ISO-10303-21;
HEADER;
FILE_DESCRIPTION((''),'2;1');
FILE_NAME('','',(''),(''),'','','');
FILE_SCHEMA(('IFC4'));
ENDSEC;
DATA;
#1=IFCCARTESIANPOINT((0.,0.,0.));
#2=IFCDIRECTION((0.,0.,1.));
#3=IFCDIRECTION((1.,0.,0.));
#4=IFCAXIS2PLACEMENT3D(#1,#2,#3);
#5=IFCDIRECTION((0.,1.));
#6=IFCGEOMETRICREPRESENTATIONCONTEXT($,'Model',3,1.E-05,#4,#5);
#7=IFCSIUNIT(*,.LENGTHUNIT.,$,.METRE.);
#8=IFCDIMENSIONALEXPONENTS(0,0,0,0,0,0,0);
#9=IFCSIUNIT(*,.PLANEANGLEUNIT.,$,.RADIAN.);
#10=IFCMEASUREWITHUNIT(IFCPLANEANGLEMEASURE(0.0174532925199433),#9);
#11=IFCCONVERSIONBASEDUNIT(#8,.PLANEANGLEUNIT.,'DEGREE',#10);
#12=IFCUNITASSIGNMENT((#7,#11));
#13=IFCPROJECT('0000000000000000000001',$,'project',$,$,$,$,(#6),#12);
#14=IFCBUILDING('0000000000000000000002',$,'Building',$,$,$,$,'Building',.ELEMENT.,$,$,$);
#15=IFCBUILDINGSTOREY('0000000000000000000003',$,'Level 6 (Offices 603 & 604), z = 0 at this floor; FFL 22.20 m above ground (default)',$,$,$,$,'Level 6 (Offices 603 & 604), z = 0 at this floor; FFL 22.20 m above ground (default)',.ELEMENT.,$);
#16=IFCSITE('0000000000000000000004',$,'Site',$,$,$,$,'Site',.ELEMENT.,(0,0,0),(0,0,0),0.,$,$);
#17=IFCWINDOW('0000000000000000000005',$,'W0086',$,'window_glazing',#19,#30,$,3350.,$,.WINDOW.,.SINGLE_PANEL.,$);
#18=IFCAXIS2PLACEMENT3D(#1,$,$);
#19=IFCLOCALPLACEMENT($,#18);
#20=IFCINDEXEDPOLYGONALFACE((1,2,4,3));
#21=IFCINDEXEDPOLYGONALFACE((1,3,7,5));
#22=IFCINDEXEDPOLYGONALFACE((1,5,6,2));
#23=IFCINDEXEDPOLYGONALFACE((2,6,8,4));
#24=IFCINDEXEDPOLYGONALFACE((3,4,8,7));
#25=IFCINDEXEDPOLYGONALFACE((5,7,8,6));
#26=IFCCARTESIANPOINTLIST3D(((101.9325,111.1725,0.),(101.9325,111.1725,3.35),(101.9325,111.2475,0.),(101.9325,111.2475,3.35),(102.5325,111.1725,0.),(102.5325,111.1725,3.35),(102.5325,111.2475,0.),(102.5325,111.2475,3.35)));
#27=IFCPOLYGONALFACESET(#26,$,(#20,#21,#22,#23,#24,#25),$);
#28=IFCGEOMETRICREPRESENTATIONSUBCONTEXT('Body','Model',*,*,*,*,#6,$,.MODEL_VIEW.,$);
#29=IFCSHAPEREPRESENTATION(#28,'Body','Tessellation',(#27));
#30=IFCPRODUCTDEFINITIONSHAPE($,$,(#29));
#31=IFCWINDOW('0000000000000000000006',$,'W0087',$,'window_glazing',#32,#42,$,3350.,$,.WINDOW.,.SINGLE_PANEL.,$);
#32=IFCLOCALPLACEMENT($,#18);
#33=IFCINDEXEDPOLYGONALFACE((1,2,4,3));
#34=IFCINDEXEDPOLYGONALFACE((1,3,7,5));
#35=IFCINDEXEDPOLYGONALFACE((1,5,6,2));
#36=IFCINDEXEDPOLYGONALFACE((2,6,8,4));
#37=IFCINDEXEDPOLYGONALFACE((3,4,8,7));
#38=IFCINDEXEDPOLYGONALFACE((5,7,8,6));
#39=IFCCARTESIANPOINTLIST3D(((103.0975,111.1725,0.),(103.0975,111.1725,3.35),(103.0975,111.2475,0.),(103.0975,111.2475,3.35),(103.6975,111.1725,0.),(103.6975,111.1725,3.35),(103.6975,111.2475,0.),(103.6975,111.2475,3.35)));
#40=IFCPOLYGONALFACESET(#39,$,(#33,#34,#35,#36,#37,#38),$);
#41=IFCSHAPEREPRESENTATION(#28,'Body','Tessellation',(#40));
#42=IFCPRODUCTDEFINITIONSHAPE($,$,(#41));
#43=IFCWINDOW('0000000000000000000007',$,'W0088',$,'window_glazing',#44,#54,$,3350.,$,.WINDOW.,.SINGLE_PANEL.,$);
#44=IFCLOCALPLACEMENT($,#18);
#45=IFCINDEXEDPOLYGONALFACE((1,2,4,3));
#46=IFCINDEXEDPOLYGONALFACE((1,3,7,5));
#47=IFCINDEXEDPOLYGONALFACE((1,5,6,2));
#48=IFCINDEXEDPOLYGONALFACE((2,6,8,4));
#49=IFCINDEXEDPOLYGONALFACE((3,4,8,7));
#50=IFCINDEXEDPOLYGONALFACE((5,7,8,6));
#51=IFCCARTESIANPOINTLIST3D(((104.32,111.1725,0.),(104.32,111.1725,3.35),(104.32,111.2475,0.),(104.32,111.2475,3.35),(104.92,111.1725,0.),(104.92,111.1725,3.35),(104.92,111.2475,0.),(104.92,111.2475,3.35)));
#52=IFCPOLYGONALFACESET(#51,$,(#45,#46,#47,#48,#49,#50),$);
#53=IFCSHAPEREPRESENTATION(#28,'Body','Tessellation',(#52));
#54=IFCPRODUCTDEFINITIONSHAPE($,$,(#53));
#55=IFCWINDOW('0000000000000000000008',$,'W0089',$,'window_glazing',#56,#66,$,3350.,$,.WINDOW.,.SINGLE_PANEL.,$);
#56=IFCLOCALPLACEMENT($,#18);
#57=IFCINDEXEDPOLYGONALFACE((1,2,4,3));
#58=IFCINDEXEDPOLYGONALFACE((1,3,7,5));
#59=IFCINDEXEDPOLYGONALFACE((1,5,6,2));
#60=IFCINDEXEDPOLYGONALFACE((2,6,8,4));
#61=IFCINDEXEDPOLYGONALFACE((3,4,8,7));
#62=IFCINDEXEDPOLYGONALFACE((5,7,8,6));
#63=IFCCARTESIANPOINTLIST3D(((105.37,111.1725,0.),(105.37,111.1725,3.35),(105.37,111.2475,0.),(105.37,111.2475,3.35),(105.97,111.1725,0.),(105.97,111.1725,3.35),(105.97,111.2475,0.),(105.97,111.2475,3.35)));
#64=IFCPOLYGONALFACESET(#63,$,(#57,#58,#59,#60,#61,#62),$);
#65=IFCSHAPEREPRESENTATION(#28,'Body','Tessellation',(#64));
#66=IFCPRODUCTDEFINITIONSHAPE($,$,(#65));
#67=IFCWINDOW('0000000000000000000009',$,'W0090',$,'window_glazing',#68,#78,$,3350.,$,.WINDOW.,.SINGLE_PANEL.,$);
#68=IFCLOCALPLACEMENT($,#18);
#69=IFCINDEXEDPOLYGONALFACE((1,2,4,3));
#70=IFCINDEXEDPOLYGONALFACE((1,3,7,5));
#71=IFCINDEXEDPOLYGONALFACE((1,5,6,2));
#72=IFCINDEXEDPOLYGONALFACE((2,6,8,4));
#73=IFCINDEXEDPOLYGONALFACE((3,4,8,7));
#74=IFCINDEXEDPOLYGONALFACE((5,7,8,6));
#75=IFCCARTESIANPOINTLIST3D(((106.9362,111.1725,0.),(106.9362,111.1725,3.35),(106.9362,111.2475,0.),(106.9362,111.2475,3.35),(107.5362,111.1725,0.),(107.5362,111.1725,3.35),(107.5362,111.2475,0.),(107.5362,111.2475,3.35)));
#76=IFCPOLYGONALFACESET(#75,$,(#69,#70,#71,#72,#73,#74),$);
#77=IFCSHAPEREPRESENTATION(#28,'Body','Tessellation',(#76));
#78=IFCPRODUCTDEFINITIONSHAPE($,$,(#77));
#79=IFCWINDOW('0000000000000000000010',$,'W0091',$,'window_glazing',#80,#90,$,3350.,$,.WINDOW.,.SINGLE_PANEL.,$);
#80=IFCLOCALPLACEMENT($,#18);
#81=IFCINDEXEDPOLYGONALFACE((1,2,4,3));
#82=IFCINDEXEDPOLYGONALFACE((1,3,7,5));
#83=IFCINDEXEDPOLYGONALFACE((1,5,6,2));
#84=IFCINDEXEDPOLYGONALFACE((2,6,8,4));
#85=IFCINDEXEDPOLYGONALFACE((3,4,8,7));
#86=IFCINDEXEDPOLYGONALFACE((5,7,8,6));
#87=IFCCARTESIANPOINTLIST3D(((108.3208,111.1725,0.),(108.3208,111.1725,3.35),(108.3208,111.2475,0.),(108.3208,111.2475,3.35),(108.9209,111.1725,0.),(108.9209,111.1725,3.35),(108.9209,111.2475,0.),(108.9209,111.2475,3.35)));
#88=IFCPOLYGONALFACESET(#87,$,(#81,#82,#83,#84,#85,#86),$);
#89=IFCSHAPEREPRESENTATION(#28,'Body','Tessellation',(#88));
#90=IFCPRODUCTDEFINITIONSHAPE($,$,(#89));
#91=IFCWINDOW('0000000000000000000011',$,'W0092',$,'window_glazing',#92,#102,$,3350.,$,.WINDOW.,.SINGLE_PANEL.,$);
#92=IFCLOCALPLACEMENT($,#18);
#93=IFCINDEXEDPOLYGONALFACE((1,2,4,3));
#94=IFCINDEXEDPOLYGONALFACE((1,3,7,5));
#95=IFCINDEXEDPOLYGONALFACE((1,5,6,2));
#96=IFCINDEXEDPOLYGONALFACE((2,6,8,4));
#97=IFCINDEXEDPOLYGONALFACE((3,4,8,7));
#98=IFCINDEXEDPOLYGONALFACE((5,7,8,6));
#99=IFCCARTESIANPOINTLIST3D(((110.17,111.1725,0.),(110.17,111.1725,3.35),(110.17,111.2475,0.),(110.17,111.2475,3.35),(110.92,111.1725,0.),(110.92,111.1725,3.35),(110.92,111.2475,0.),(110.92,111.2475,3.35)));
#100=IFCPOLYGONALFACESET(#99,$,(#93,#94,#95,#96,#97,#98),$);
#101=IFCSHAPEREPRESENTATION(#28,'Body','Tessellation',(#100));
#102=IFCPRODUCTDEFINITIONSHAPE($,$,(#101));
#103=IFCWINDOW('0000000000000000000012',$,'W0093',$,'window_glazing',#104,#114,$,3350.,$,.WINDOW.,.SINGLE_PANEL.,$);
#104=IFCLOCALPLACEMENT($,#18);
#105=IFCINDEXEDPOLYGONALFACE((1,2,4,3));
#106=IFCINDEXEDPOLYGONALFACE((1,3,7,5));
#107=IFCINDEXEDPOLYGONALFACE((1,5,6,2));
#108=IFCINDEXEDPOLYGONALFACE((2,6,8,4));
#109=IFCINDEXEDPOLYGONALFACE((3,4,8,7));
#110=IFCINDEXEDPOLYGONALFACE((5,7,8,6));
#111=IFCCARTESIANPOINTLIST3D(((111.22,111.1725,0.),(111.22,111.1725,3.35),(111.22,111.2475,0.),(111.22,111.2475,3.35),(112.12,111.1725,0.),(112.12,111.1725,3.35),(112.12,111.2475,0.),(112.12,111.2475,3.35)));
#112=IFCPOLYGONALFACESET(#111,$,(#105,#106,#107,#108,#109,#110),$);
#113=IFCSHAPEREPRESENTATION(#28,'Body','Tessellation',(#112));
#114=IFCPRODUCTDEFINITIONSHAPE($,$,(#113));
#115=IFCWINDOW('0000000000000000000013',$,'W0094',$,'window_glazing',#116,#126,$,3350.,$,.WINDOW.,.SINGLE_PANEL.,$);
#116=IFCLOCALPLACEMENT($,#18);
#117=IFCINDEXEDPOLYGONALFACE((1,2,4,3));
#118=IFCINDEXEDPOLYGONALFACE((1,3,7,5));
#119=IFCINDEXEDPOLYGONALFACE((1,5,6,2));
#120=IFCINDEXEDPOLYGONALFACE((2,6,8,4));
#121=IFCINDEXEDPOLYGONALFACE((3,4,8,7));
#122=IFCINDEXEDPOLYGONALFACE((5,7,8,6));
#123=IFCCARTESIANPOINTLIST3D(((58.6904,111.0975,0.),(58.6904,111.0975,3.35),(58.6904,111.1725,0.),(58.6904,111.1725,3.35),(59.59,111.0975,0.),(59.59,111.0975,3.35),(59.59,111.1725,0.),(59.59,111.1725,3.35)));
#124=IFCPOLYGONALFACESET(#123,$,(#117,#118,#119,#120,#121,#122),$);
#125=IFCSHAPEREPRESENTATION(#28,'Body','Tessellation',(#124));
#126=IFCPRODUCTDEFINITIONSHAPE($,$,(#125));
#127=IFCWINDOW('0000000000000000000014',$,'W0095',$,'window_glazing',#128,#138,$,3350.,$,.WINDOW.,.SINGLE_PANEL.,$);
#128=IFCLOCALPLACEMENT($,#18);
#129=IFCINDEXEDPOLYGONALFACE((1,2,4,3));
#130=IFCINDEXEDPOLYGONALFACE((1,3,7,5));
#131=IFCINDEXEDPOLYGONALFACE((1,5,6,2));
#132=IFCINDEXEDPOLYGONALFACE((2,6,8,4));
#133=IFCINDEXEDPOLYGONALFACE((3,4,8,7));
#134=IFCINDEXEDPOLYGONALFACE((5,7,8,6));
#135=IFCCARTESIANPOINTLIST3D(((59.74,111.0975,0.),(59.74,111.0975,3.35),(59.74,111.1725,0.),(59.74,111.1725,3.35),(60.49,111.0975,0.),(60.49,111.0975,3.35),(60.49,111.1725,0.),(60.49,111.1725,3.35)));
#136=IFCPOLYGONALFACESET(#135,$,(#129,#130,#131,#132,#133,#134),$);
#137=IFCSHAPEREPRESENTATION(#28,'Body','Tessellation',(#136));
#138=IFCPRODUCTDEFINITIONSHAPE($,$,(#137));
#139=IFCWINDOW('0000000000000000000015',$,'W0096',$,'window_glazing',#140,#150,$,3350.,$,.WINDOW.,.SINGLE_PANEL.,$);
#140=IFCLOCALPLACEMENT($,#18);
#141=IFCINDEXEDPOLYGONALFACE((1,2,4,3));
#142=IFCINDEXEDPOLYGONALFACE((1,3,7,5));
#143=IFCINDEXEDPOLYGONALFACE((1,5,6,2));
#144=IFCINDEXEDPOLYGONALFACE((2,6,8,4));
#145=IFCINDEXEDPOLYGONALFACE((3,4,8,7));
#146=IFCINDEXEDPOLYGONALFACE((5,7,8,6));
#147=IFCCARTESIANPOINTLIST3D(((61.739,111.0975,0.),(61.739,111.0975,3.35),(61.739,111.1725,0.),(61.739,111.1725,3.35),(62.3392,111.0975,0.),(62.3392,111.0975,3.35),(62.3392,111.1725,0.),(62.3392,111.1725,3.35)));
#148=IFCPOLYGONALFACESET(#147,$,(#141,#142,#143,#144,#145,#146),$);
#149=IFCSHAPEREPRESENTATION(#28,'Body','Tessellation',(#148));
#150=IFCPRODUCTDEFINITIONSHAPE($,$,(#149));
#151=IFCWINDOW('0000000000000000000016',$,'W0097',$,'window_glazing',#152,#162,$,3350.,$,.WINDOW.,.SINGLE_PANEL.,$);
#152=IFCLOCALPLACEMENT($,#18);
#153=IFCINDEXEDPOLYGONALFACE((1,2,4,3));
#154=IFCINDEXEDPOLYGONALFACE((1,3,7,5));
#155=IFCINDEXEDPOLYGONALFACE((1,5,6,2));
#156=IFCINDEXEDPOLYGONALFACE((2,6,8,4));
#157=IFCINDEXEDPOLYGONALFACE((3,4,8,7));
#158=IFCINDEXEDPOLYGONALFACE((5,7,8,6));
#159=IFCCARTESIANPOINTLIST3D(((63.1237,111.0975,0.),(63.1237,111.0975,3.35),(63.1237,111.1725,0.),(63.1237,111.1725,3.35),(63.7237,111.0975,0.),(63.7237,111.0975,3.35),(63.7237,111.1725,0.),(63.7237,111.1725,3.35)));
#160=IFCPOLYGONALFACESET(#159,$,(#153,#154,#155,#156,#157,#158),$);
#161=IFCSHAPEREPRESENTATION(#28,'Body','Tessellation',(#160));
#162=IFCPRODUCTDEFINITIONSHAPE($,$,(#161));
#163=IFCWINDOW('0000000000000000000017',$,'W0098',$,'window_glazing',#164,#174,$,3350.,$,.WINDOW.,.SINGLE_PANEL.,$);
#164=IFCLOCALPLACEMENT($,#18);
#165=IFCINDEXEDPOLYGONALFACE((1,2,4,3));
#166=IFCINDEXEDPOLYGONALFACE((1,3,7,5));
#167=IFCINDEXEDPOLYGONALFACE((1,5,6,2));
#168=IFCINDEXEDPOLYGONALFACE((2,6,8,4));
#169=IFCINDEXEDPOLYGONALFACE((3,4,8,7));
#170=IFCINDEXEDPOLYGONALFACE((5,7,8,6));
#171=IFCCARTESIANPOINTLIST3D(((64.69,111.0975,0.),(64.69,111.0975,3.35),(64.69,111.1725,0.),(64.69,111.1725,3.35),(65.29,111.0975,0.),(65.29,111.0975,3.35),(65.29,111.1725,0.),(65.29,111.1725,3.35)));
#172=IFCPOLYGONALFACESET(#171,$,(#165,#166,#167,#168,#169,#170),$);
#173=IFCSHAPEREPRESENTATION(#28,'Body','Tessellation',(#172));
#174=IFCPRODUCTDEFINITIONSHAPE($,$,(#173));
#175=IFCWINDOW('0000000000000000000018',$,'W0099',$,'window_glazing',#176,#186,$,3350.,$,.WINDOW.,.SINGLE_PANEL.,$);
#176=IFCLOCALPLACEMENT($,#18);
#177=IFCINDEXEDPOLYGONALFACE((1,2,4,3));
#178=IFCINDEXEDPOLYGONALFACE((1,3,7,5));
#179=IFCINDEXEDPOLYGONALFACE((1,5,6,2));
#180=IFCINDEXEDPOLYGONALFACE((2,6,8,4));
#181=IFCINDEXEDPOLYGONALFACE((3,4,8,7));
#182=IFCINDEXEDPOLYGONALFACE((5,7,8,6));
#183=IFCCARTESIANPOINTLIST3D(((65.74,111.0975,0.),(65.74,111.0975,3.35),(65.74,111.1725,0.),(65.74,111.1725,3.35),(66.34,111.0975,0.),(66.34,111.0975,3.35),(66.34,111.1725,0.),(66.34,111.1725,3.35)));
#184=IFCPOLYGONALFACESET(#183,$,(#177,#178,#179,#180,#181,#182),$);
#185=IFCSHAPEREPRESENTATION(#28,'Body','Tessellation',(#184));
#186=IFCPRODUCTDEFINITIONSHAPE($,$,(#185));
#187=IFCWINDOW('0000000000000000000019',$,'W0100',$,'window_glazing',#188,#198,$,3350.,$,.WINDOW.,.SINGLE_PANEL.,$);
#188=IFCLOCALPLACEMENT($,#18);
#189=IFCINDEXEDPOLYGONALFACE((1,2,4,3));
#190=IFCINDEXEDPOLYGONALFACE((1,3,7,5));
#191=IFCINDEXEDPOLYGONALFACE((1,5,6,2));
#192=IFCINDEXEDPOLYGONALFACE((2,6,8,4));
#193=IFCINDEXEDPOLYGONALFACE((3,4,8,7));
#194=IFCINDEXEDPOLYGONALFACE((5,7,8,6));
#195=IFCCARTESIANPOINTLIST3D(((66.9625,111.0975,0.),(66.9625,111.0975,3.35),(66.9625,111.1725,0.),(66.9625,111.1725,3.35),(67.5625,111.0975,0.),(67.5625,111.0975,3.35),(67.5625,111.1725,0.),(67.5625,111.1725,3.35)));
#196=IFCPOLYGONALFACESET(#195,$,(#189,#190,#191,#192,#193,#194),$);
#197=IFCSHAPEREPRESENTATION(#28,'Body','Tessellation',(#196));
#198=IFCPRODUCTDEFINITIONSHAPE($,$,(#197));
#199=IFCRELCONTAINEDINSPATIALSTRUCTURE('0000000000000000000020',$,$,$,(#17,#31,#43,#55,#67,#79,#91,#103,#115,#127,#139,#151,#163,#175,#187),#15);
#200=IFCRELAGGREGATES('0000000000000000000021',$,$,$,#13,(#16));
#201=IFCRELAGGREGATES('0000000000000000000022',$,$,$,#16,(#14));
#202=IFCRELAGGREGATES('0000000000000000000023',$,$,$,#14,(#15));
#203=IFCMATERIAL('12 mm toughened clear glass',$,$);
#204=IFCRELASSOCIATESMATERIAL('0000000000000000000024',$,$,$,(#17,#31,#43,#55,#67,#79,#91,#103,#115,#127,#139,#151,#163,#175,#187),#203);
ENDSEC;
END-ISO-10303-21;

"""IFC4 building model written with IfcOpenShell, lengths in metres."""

from ifc_helpers import new_model, entity, si_unit, converted_unit, direction, frame, frame_2d, origin_with_axes, place, context, subcontext, project, spatial, rectangle, extrude, material, element, save


model = new_model("IFC4")

# Units and contexts
model_context = context("Model", 3, precision=1e-05, world=origin_with_axes(), true_north=direction((0.0, 1.0)))
body_context = subcontext(model_context, "Body", "Model", "MODEL_VIEW")
ifc_project = project(units=[si_unit("LENGTHUNIT", "METRE"), converted_unit("PLANEANGLEUNIT", "DEGREE", entity("IfcPlaneAngleMeasure", 0.0174532925199433), si_unit("PLANEANGLEUNIT", "RADIAN"), dimensions=[0, 0, 0, 0, 0, 0, 0])], contexts=[model_context])

# Site, building, storey
site = spatial("IfcSite", under=ifc_project, Name="Site", LongName="Site", CompositionType="ELEMENT", RefLatitude=(0, 0, 0), RefLongitude=(0, 0, 0), RefElevation=0.0)
building = spatial("IfcBuilding", under=site, Name="Building", LongName="Building", CompositionType="ELEMENT")
storey = spatial("IfcBuildingStorey", under=building, Name="Level 6 (Offices 603 & 604), z = 0 at this floor; FFL 22.20 m above ground (default)", LongName="Level 6 (Offices 603 & 604), z = 0 at this floor; FFL 22.20 m above ground (default)", CompositionType="ELEMENT")

# Windows
ifc_material_1 = material(Name="12 mm toughened clear glass")
placement = place(None, origin_with_axes())
element("IfcWindow", 1, at=placement, inside=storey, material=ifc_material_1, Name="W0086", ObjectType="window_glazing", OverallHeight=3350.0, PartitioningType="SINGLE_PANEL", PredefinedType="WINDOW", context=body_context, shape_type="SweptSolid", body=[
    extrude(rectangle(XDim=0.6, YDim=0.075, at=frame_2d((0.0, 0.0), x_axis=(1.0, 0.0))), frame((102.2325, 111.21, 0.0), z_axis=(0.0, 0.0, 1.0), x_axis=(1.0, 0.0, 0.0)), (0.0, 0.0, 1.0), 3.35),
])
element("IfcWindow", 2, at=placement, inside=storey, material=ifc_material_1, Name="W0087", ObjectType="window_glazing", OverallHeight=3350.0, PartitioningType="SINGLE_PANEL", PredefinedType="WINDOW", context=body_context, shape_type="SweptSolid", body=[
    extrude(rectangle(XDim=0.6, YDim=0.075, at=frame_2d((0.0, 0.0), x_axis=(1.0, 0.0))), frame((103.3975, 111.21, 0.0), z_axis=(0.0, 0.0, 1.0), x_axis=(1.0, 0.0, 0.0)), (0.0, 0.0, 1.0), 3.35),
])
element("IfcWindow", 3, at=placement, inside=storey, material=ifc_material_1, Name="W0088", ObjectType="window_glazing", OverallHeight=3350.0, PartitioningType="SINGLE_PANEL", PredefinedType="WINDOW", context=body_context, shape_type="SweptSolid", body=[
    extrude(rectangle(XDim=0.6, YDim=0.075, at=frame_2d((0.0, 0.0), x_axis=(1.0, 0.0))), frame((104.62, 111.21, 0.0), z_axis=(0.0, 0.0, 1.0), x_axis=(1.0, 0.0, 0.0)), (0.0, 0.0, 1.0), 3.35),
])
element("IfcWindow", 4, at=placement, inside=storey, material=ifc_material_1, Name="W0089", ObjectType="window_glazing", OverallHeight=3350.0, PartitioningType="SINGLE_PANEL", PredefinedType="WINDOW", context=body_context, shape_type="SweptSolid", body=[
    extrude(rectangle(XDim=0.6, YDim=0.075, at=frame_2d((0.0, 0.0), x_axis=(1.0, 0.0))), frame((105.67, 111.21, 0.0), z_axis=(0.0, 0.0, 1.0), x_axis=(1.0, 0.0, 0.0)), (0.0, 0.0, 1.0), 3.35),
])
element("IfcWindow", 5, at=placement, inside=storey, material=ifc_material_1, Name="W0090", ObjectType="window_glazing", OverallHeight=3350.0, PartitioningType="SINGLE_PANEL", PredefinedType="WINDOW", context=body_context, shape_type="SweptSolid", body=[
    extrude(rectangle(XDim=0.6, YDim=0.075, at=frame_2d((0.0, 0.0), x_axis=(1.0, 0.0))), frame((107.2362, 111.21, 0.0), z_axis=(0.0, 0.0, 1.0), x_axis=(1.0, 0.0, 0.0)), (0.0, 0.0, 1.0), 3.35),
])
element("IfcWindow", 6, at=placement, inside=storey, material=ifc_material_1, Name="W0091", ObjectType="window_glazing", OverallHeight=3350.0, PartitioningType="SINGLE_PANEL", PredefinedType="WINDOW", context=body_context, shape_type="SweptSolid", body=[
    extrude(rectangle(XDim=0.6001, YDim=0.075, at=frame_2d((0.0, 0.0), x_axis=(1.0, 0.0))), frame((108.6209, 111.21, 0.0), z_axis=(0.0, 0.0, 1.0), x_axis=(1.0, 0.0, 0.0)), (0.0, 0.0, 1.0), 3.35),
])
element("IfcWindow", 7, at=placement, inside=storey, material=ifc_material_1, Name="W0092", ObjectType="window_glazing", OverallHeight=3350.0, PartitioningType="SINGLE_PANEL", PredefinedType="WINDOW", context=body_context, shape_type="SweptSolid", body=[
    extrude(rectangle(XDim=0.75, YDim=0.075, at=frame_2d((0.0, 0.0), x_axis=(1.0, 0.0))), frame((110.545, 111.21, 0.0), z_axis=(0.0, 0.0, 1.0), x_axis=(1.0, 0.0, 0.0)), (0.0, 0.0, 1.0), 3.35),
])
element("IfcWindow", 8, at=placement, inside=storey, material=ifc_material_1, Name="W0093", ObjectType="window_glazing", OverallHeight=3350.0, PartitioningType="SINGLE_PANEL", PredefinedType="WINDOW", context=body_context, shape_type="SweptSolid", body=[
    extrude(rectangle(XDim=0.9, YDim=0.075, at=frame_2d((0.0, 0.0), x_axis=(1.0, 0.0))), frame((111.67, 111.21, 0.0), z_axis=(0.0, 0.0, 1.0), x_axis=(1.0, 0.0, 0.0)), (0.0, 0.0, 1.0), 3.35),
])
element("IfcWindow", 9, at=placement, inside=storey, material=ifc_material_1, Name="W0094", ObjectType="window_glazing", OverallHeight=3350.0, PartitioningType="SINGLE_PANEL", PredefinedType="WINDOW", context=body_context, shape_type="SweptSolid", body=[
    extrude(rectangle(XDim=0.8996, YDim=0.075, at=frame_2d((0.0, 0.0), x_axis=(1.0, 0.0))), frame((59.1402, 111.135, 0.0), z_axis=(0.0, 0.0, 1.0), x_axis=(1.0, 0.0, 0.0)), (0.0, 0.0, 1.0), 3.35),
])
element("IfcWindow", 10, at=placement, inside=storey, material=ifc_material_1, Name="W0095", ObjectType="window_glazing", OverallHeight=3350.0, PartitioningType="SINGLE_PANEL", PredefinedType="WINDOW", context=body_context, shape_type="SweptSolid", body=[
    extrude(rectangle(XDim=0.75, YDim=0.075, at=frame_2d((0.0, 0.0), x_axis=(1.0, 0.0))), frame((60.115, 111.135, 0.0), z_axis=(0.0, 0.0, 1.0), x_axis=(1.0, 0.0, 0.0)), (0.0, 0.0, 1.0), 3.35),
])
element("IfcWindow", 11, at=placement, inside=storey, material=ifc_material_1, Name="W0096", ObjectType="window_glazing", OverallHeight=3350.0, PartitioningType="SINGLE_PANEL", PredefinedType="WINDOW", context=body_context, shape_type="SweptSolid", body=[
    extrude(rectangle(XDim=0.6002, YDim=0.075, at=frame_2d((0.0, 0.0), x_axis=(1.0, 0.0))), frame((62.0391, 111.135, 0.0), z_axis=(0.0, 0.0, 1.0), x_axis=(1.0, 0.0, 0.0)), (0.0, 0.0, 1.0), 3.35),
])
element("IfcWindow", 12, at=placement, inside=storey, material=ifc_material_1, Name="W0097", ObjectType="window_glazing", OverallHeight=3350.0, PartitioningType="SINGLE_PANEL", PredefinedType="WINDOW", context=body_context, shape_type="SweptSolid", body=[
    extrude(rectangle(XDim=0.6, YDim=0.075, at=frame_2d((0.0, 0.0), x_axis=(1.0, 0.0))), frame((63.4237, 111.135, 0.0), z_axis=(0.0, 0.0, 1.0), x_axis=(1.0, 0.0, 0.0)), (0.0, 0.0, 1.0), 3.35),
])
element("IfcWindow", 13, at=placement, inside=storey, material=ifc_material_1, Name="W0098", ObjectType="window_glazing", OverallHeight=3350.0, PartitioningType="SINGLE_PANEL", PredefinedType="WINDOW", context=body_context, shape_type="SweptSolid", body=[
    extrude(rectangle(XDim=0.6, YDim=0.075, at=frame_2d((0.0, 0.0), x_axis=(1.0, 0.0))), frame((64.99, 111.135, 0.0), z_axis=(0.0, 0.0, 1.0), x_axis=(1.0, 0.0, 0.0)), (0.0, 0.0, 1.0), 3.35),
])
element("IfcWindow", 14, at=placement, inside=storey, material=ifc_material_1, Name="W0099", ObjectType="window_glazing", OverallHeight=3350.0, PartitioningType="SINGLE_PANEL", PredefinedType="WINDOW", context=body_context, shape_type="SweptSolid", body=[
    extrude(rectangle(XDim=0.6, YDim=0.075, at=frame_2d((0.0, 0.0), x_axis=(1.0, 0.0))), frame((66.04, 111.135, 0.0), z_axis=(0.0, 0.0, 1.0), x_axis=(1.0, 0.0, 0.0)), (0.0, 0.0, 1.0), 3.35),
])
element("IfcWindow", 15, at=placement, inside=storey, material=ifc_material_1, Name="W0100", ObjectType="window_glazing", OverallHeight=3350.0, PartitioningType="SINGLE_PANEL", PredefinedType="WINDOW", context=body_context, shape_type="SweptSolid", body=[
    extrude(rectangle(XDim=0.6, YDim=0.075, at=frame_2d((0.0, 0.0), x_axis=(1.0, 0.0))), frame((67.2625, 111.135, 0.0), z_axis=(0.0, 0.0, 1.0), x_axis=(1.0, 0.0, 0.0)), (0.0, 0.0, 1.0), 3.35),
])

save(model, "model.ifc")
